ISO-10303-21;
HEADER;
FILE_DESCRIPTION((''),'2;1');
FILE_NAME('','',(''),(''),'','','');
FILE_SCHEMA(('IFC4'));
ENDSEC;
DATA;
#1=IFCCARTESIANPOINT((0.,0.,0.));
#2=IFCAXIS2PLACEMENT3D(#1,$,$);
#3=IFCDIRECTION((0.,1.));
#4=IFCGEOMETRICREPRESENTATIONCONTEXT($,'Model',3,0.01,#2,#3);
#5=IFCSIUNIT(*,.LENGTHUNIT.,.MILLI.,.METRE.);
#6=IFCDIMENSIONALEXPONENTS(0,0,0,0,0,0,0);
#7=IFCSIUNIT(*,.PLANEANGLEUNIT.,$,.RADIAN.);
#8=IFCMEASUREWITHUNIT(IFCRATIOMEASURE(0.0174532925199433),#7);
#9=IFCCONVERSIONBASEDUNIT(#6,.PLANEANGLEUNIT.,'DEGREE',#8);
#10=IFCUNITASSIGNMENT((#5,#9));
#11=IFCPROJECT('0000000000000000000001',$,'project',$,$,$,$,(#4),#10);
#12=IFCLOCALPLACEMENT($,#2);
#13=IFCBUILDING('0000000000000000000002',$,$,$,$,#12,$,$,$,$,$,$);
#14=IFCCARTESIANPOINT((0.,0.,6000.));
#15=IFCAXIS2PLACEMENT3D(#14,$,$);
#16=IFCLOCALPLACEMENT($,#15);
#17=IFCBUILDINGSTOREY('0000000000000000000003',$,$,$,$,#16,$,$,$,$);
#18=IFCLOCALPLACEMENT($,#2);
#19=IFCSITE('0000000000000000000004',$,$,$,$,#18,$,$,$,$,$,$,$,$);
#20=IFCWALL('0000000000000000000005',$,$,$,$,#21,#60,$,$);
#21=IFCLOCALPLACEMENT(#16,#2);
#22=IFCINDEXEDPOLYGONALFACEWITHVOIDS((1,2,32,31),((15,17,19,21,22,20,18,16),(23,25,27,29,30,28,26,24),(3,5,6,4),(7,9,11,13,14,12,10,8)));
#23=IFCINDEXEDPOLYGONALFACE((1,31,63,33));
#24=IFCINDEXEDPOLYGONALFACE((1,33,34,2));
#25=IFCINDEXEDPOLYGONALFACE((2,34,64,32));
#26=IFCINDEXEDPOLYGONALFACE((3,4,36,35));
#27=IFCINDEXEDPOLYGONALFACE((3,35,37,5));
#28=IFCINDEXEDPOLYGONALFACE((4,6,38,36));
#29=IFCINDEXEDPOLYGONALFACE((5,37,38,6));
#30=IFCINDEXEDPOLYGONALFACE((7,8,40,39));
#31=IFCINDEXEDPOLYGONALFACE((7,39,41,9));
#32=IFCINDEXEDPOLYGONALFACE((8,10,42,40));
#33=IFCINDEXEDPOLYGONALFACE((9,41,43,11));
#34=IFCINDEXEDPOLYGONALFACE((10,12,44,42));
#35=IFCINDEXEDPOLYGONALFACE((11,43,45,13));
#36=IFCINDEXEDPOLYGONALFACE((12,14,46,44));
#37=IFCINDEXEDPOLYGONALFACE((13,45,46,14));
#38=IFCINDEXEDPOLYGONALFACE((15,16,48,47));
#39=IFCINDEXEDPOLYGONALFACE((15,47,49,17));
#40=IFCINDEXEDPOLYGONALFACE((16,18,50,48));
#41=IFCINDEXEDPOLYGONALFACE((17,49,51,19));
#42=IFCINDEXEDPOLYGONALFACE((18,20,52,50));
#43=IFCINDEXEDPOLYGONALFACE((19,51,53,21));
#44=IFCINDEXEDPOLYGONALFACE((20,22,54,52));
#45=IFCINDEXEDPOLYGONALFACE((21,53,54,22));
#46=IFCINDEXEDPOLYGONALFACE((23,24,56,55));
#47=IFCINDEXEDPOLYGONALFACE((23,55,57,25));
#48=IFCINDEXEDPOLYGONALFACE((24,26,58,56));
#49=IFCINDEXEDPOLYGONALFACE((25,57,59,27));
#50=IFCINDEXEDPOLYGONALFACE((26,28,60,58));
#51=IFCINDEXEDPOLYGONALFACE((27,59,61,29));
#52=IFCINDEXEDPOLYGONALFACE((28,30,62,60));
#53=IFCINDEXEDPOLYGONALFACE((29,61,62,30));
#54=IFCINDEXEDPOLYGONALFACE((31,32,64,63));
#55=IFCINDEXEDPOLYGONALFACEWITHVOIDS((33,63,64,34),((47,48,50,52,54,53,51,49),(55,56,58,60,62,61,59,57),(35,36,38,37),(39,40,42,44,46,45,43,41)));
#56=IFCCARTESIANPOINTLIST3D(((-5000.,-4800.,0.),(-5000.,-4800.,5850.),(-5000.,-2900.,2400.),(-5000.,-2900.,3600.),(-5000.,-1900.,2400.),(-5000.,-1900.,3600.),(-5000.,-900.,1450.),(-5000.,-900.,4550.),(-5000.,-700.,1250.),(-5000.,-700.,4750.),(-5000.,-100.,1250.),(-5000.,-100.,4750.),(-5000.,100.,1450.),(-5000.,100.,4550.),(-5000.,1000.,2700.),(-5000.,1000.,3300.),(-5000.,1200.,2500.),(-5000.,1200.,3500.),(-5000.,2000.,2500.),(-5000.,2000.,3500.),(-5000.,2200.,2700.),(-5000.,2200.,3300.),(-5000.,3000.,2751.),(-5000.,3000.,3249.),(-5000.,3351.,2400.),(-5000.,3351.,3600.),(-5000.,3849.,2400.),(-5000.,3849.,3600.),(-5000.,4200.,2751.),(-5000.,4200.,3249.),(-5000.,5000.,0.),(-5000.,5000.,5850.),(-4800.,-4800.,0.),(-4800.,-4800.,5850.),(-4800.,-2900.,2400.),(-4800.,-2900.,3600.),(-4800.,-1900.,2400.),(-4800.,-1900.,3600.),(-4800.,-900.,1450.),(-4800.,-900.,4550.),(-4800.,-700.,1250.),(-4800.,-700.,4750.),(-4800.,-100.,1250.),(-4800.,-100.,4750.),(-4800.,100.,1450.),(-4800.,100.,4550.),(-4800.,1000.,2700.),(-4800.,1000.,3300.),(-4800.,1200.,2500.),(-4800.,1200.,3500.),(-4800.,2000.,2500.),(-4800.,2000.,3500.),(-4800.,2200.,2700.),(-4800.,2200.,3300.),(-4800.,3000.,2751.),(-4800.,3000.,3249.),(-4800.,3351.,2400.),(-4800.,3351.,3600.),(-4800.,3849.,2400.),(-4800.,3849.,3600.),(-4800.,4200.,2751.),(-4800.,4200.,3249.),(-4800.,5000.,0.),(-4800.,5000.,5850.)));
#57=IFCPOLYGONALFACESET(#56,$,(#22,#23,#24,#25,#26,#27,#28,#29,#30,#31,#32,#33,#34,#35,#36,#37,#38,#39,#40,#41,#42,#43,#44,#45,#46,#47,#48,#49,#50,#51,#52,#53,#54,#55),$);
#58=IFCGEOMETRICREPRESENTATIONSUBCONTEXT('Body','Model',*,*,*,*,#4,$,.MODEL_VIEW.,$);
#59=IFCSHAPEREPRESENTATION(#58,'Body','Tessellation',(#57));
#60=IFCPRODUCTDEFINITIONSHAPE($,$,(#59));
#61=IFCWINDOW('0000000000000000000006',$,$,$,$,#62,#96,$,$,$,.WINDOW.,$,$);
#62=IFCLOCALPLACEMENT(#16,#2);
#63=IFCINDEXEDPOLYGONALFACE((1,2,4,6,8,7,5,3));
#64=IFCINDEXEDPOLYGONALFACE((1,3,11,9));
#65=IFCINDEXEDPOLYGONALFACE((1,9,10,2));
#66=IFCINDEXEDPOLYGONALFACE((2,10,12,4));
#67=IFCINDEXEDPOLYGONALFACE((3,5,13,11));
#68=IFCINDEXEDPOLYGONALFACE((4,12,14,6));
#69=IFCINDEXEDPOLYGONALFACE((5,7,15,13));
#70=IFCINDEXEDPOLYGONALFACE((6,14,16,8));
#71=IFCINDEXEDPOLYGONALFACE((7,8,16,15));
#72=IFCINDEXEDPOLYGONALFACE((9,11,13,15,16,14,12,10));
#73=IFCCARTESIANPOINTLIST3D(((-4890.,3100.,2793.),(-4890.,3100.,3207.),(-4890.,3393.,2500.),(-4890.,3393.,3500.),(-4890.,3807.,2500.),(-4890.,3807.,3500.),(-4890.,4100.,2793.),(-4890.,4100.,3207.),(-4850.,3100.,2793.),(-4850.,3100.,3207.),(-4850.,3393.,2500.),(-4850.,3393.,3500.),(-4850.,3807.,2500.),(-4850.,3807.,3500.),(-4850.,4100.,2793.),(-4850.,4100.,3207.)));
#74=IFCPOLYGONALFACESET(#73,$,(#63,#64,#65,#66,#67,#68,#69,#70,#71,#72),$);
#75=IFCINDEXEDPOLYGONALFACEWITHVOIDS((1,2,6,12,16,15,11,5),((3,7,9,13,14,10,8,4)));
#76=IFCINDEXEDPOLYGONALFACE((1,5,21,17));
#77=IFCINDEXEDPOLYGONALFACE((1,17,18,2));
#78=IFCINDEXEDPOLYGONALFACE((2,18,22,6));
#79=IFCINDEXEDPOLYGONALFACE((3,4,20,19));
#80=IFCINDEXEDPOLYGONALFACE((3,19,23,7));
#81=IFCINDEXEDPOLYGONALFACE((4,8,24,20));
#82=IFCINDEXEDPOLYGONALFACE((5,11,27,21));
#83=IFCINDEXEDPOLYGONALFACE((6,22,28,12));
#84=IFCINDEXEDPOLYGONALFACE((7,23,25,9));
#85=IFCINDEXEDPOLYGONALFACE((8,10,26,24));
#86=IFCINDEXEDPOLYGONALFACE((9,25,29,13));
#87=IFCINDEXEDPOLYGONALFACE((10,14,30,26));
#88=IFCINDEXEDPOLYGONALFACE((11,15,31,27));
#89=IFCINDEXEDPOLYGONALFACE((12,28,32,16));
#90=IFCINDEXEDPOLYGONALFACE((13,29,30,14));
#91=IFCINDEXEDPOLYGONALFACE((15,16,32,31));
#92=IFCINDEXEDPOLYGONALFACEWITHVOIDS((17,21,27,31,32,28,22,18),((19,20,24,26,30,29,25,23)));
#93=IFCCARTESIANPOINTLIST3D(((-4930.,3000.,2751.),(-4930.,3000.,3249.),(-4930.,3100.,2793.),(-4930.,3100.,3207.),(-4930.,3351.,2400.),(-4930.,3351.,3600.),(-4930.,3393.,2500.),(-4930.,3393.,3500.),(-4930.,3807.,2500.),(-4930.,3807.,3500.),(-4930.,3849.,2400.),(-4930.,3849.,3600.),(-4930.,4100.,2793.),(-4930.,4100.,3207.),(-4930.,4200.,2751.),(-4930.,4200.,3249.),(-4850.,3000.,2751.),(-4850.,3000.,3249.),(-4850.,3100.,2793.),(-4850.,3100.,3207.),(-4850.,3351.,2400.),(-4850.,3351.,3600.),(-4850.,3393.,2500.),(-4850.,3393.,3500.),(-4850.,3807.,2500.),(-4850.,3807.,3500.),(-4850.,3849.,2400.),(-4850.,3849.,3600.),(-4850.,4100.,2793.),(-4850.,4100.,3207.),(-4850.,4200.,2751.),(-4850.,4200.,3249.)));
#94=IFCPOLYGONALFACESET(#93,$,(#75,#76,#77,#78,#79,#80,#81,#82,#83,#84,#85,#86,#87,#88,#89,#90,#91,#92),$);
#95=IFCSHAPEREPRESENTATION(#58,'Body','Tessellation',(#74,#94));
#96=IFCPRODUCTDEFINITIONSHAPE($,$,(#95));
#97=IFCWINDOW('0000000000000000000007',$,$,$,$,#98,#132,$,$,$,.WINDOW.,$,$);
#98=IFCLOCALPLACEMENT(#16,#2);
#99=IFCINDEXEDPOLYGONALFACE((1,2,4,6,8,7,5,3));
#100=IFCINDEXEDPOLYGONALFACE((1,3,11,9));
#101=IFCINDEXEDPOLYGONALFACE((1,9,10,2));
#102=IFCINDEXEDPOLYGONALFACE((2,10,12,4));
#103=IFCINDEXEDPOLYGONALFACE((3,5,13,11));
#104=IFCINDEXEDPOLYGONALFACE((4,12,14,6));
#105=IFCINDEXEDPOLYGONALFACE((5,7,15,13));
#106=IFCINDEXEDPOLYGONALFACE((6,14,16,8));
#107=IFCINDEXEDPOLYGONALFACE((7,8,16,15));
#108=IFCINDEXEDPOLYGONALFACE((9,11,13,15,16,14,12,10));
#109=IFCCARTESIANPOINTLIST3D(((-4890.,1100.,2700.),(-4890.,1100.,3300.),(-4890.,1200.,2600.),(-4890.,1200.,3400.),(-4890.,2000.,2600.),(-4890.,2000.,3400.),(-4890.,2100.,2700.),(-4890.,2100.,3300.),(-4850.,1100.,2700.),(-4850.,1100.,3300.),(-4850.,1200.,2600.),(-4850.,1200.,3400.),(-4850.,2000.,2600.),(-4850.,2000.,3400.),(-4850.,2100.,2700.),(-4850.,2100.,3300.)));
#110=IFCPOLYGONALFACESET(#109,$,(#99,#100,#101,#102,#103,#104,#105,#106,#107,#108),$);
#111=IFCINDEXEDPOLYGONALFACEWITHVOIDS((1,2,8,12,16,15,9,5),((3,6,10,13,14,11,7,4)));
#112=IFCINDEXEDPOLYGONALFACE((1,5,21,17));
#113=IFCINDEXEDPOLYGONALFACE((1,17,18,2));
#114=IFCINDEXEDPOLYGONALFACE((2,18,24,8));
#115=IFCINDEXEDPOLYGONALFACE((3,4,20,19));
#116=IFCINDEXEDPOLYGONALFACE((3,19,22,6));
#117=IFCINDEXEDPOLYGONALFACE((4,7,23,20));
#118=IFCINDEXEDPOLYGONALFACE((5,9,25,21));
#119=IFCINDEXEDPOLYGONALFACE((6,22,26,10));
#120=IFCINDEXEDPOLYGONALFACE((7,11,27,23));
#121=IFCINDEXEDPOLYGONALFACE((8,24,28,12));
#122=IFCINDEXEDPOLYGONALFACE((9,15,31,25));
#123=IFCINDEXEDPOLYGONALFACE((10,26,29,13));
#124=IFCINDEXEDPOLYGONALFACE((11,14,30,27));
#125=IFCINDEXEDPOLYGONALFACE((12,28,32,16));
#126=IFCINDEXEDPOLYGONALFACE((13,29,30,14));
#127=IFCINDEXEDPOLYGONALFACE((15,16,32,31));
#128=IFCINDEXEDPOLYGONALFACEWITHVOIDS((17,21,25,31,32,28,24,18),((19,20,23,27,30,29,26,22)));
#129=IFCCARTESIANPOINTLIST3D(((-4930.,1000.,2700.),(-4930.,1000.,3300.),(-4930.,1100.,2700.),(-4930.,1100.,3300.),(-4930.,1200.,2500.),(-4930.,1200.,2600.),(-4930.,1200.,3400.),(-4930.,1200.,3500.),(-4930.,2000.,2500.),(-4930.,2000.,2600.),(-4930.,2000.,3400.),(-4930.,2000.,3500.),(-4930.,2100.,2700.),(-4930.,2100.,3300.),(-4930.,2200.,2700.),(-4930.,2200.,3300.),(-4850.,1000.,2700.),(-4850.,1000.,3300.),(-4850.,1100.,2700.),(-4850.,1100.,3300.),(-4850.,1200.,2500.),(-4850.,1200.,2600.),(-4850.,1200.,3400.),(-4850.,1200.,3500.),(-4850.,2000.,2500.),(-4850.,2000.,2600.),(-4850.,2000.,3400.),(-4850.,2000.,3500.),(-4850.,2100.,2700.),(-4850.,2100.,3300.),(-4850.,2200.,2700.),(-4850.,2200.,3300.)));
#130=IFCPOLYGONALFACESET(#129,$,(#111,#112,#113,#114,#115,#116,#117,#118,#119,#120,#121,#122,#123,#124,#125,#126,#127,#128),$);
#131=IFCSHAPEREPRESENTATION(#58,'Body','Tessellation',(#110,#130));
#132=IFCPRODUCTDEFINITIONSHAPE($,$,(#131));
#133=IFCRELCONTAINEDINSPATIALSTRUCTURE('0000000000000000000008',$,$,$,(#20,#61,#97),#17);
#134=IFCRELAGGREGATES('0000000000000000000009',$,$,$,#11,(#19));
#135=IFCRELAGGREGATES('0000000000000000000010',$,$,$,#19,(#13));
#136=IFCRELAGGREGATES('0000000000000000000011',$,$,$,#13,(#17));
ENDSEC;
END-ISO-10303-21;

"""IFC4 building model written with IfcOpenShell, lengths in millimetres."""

from ifc_helpers import new_model, entity, si_unit, converted_unit, direction, frame, origin, origin_2d, place, context, subcontext, project, spatial, polyline, rectangle, outline, extrude, element, save


model = new_model("IFC4")

# Units and contexts
model_context = context("Model", 3, precision=0.01, world=origin(), true_north=direction((0.0, 1.0)))
body_context = subcontext(model_context, "Body", "Model", "MODEL_VIEW")
ifc_project = project(units=[si_unit("LENGTHUNIT", "METRE", prefix="MILLI"), converted_unit("PLANEANGLEUNIT", "DEGREE", entity("IfcRatioMeasure", 0.0174532925199433), si_unit("PLANEANGLEUNIT", "RADIAN"), dimensions=[0, 0, 0, 0, 0, 0, 0])], contexts=[model_context])

# Site, building, storey
site_placement = place(None, origin())
site = spatial("IfcSite", under=ifc_project, at=site_placement)
building_placement = place(None, origin())
building = spatial("IfcBuilding", under=site, at=building_placement)
storey_placement = place(None, frame((0.0, 0.0, 6000.0)))
storey = spatial("IfcBuildingStorey", under=building, at=storey_placement)

# Shared definitions
cartesian_point_1 = entity("IfcCartesianPoint", [-500.0, -207.0])
shared_polyline_1 = entity("IfcPolyline", [cartesian_point_1, entity("IfcCartesianPoint", [-500.0, 207.0]), entity("IfcCartesianPoint", [-207.0, 500.0]), entity("IfcCartesianPoint", [207.0, 500.0]), entity("IfcCartesianPoint", [500.0, 207.0]), entity("IfcCartesianPoint", [500.0, -207.0]), entity("IfcCartesianPoint", [207.0, -500.0]), entity("IfcCartesianPoint", [-207.0, -500.0]), cartesian_point_1])
cartesian_point_2 = entity("IfcCartesianPoint", [-500.0, -300.0])
shared_polyline_2 = entity("IfcPolyline", [cartesian_point_2, entity("IfcCartesianPoint", [-500.0, 300.0]), entity("IfcCartesianPoint", [-400.0, 400.0]), entity("IfcCartesianPoint", [400.0, 400.0]), entity("IfcCartesianPoint", [500.0, 300.0]), entity("IfcCartesianPoint", [500.0, -300.0]), entity("IfcCartesianPoint", [400.0, -400.0]), entity("IfcCartesianPoint", [-400.0, -400.0]), cartesian_point_2])

# Wall, openings
wall_1_placement = place(storey_placement, frame((-4900.0, 100.0, 0.0), z_axis=(0.0, 0.0, 1.0), x_axis=(0.0, -1.0, 0.0)))
wall_1 = element("IfcWall", 1, at=wall_1_placement, inside=storey, context=body_context, shape_type="SweptSolid", body=[
    extrude(rectangle(XDim=9800.0, YDim=200.0, at=origin_2d()), origin(), (0.0, 0.0, 1.0), 5850.0),
])
window_1_placement = place(wall_1_placement, frame((-3500.0, 50.0, 3000.0)))
opening_1_placement = place(window_1_placement, frame((0.0, 50.0, 0.0)))
element("IfcOpeningElement", 2, at=opening_1_placement, cuts=wall_1, context=body_context, shape_type="SweptSolid", body=[
    extrude(outline(polyline([(-600.0, -249.0), (-600.0, 249.0), (-249.0, 600.0), (249.0, 600.0), (600.0, 249.0), (600.0, -249.0), (249.0, -600.0), (-249.0, -600.0), (-600.0, -249.0)])), frame((0.0, 0.0, 0.0), z_axis=(0.0, -1.0, 0.0), x_axis=(1.0, 0.0, 0.0)), (0.0, 0.0, 1.0), 200.0),
])
window_2_placement = place(wall_1_placement, frame((-1500.0, 50.0, 3000.0)))
opening_2_placement = place(window_2_placement, frame((0.0, 50.0, 0.0)))
element("IfcOpeningElement", 3, at=opening_2_placement, cuts=wall_1, context=body_context, shape_type="SweptSolid", body=[
    extrude(outline(polyline([(-600.0, -300.0), (-600.0, 300.0), (-400.0, 500.0), (400.0, 500.0), (600.0, 300.0), (600.0, -300.0), (400.0, -500.0), (-400.0, -500.0), (-600.0, -300.0)])), frame((0.0, 0.0, 0.0), z_axis=(0.0, -1.0, 0.0), x_axis=(1.0, 0.0, 0.0)), (0.0, 0.0, 1.0), 200.0),
])
window_3_placement = place(wall_1_placement, frame((500.0, 50.0, 3000.0)))
opening_3_placement = place(window_3_placement, frame((0.0, 50.0, 0.0)))
element("IfcOpeningElement", 4, at=opening_3_placement, cuts=wall_1, context=body_context, shape_type="SweptSolid", body=[
    extrude(outline(polyline([(-500.0, -1550.0), (-500.0, 1550.0), (-300.0, 1750.0), (300.0, 1750.0), (500.0, 1550.0), (500.0, -1550.0), (300.0, -1750.0), (-300.0, -1750.0), (-500.0, -1550.0)])), frame((0.0, 0.0, 0.0), z_axis=(0.0, -1.0, 0.0), x_axis=(1.0, 0.0, 0.0)), (0.0, 0.0, 1.0), 200.0),
])
window_4_placement = place(wall_1_placement, frame((2500.0, 50.0, 3000.0)))
opening_4_placement = place(window_4_placement, frame((0.0, 50.0, 0.0)))
element("IfcOpeningElement", 5, at=opening_4_placement, cuts=wall_1, context=body_context, shape_type="SweptSolid", body=[
    extrude(outline(polyline([(-500.0, -600.0), (-500.0, 600.0), (-500.0, 600.0), (500.0, 600.0), (500.0, 600.0), (500.0, -600.0), (500.0, -600.0), (-500.0, -600.0), (-500.0, -600.0)])), frame((0.0, 0.0, 0.0), z_axis=(0.0, -1.0, 0.0), x_axis=(1.0, 0.0, 0.0)), (0.0, 0.0, 1.0), 200.0),
])

# Windows
cartesian_point_3 = entity("IfcCartesianPoint", [-600.0, -249.0])
element("IfcWindow", 6, at=window_1_placement, inside=storey, PredefinedType="WINDOW", context=body_context, shape_type="SweptSolid", body=[
    entity("IfcExtrudedAreaSolid", entity("IfcArbitraryClosedProfileDef", "AREA", None, shared_polyline_1), entity("IfcAxis2Placement3D", entity("IfcCartesianPoint", [0.0, 0.0, 0.0]), entity("IfcDirection", [0.0, -1.0, 0.0]), entity("IfcDirection", [1.0, 0.0, 0.0])), entity("IfcDirection", [0.0, 0.0, 1.0]), 40.0),
    entity("IfcExtrudedAreaSolid", entity("IfcArbitraryProfileDefWithVoids", "AREA", None, entity("IfcPolyline", [cartesian_point_3, entity("IfcCartesianPoint", [-600.0, 249.0]), entity("IfcCartesianPoint", [-249.0, 600.0]), entity("IfcCartesianPoint", [249.0, 600.0]), entity("IfcCartesianPoint", [600.0, 249.0]), entity("IfcCartesianPoint", [600.0, -249.0]), entity("IfcCartesianPoint", [249.0, -600.0]), entity("IfcCartesianPoint", [-249.0, -600.0]), cartesian_point_3]), [shared_polyline_1]), entity("IfcAxis2Placement3D", entity("IfcCartesianPoint", [0.0, 0.0, 0.0]), entity("IfcDirection", [0.0, -1.0, 0.0]), entity("IfcDirection", [1.0, 0.0, 0.0])), entity("IfcDirection", [0.0, 0.0, 1.0]), 80.0),
])
cartesian_point_4 = entity("IfcCartesianPoint", [-600.0, -300.0])
element("IfcWindow", 7, at=window_2_placement, inside=storey, PredefinedType="WINDOW", context=body_context, shape_type="SweptSolid", body=[
    entity("IfcExtrudedAreaSolid", entity("IfcArbitraryClosedProfileDef", "AREA", None, shared_polyline_2), entity("IfcAxis2Placement3D", entity("IfcCartesianPoint", [0.0, 0.0, 0.0]), entity("IfcDirection", [0.0, -1.0, 0.0]), entity("IfcDirection", [1.0, 0.0, 0.0])), entity("IfcDirection", [0.0, 0.0, 1.0]), 40.0),
    entity("IfcExtrudedAreaSolid", entity("IfcArbitraryProfileDefWithVoids", "AREA", None, entity("IfcPolyline", [cartesian_point_4, entity("IfcCartesianPoint", [-600.0, 300.0]), entity("IfcCartesianPoint", [-400.0, 500.0]), entity("IfcCartesianPoint", [400.0, 500.0]), entity("IfcCartesianPoint", [600.0, 300.0]), entity("IfcCartesianPoint", [600.0, -300.0]), entity("IfcCartesianPoint", [400.0, -500.0]), entity("IfcCartesianPoint", [-400.0, -500.0]), cartesian_point_4]), [shared_polyline_2]), entity("IfcAxis2Placement3D", entity("IfcCartesianPoint", [0.0, 0.0, 0.0]), entity("IfcDirection", [0.0, -1.0, 0.0]), entity("IfcDirection", [1.0, 0.0, 0.0])), entity("IfcDirection", [0.0, 0.0, 1.0]), 80.0),
])

save(model, "model.ifc")
